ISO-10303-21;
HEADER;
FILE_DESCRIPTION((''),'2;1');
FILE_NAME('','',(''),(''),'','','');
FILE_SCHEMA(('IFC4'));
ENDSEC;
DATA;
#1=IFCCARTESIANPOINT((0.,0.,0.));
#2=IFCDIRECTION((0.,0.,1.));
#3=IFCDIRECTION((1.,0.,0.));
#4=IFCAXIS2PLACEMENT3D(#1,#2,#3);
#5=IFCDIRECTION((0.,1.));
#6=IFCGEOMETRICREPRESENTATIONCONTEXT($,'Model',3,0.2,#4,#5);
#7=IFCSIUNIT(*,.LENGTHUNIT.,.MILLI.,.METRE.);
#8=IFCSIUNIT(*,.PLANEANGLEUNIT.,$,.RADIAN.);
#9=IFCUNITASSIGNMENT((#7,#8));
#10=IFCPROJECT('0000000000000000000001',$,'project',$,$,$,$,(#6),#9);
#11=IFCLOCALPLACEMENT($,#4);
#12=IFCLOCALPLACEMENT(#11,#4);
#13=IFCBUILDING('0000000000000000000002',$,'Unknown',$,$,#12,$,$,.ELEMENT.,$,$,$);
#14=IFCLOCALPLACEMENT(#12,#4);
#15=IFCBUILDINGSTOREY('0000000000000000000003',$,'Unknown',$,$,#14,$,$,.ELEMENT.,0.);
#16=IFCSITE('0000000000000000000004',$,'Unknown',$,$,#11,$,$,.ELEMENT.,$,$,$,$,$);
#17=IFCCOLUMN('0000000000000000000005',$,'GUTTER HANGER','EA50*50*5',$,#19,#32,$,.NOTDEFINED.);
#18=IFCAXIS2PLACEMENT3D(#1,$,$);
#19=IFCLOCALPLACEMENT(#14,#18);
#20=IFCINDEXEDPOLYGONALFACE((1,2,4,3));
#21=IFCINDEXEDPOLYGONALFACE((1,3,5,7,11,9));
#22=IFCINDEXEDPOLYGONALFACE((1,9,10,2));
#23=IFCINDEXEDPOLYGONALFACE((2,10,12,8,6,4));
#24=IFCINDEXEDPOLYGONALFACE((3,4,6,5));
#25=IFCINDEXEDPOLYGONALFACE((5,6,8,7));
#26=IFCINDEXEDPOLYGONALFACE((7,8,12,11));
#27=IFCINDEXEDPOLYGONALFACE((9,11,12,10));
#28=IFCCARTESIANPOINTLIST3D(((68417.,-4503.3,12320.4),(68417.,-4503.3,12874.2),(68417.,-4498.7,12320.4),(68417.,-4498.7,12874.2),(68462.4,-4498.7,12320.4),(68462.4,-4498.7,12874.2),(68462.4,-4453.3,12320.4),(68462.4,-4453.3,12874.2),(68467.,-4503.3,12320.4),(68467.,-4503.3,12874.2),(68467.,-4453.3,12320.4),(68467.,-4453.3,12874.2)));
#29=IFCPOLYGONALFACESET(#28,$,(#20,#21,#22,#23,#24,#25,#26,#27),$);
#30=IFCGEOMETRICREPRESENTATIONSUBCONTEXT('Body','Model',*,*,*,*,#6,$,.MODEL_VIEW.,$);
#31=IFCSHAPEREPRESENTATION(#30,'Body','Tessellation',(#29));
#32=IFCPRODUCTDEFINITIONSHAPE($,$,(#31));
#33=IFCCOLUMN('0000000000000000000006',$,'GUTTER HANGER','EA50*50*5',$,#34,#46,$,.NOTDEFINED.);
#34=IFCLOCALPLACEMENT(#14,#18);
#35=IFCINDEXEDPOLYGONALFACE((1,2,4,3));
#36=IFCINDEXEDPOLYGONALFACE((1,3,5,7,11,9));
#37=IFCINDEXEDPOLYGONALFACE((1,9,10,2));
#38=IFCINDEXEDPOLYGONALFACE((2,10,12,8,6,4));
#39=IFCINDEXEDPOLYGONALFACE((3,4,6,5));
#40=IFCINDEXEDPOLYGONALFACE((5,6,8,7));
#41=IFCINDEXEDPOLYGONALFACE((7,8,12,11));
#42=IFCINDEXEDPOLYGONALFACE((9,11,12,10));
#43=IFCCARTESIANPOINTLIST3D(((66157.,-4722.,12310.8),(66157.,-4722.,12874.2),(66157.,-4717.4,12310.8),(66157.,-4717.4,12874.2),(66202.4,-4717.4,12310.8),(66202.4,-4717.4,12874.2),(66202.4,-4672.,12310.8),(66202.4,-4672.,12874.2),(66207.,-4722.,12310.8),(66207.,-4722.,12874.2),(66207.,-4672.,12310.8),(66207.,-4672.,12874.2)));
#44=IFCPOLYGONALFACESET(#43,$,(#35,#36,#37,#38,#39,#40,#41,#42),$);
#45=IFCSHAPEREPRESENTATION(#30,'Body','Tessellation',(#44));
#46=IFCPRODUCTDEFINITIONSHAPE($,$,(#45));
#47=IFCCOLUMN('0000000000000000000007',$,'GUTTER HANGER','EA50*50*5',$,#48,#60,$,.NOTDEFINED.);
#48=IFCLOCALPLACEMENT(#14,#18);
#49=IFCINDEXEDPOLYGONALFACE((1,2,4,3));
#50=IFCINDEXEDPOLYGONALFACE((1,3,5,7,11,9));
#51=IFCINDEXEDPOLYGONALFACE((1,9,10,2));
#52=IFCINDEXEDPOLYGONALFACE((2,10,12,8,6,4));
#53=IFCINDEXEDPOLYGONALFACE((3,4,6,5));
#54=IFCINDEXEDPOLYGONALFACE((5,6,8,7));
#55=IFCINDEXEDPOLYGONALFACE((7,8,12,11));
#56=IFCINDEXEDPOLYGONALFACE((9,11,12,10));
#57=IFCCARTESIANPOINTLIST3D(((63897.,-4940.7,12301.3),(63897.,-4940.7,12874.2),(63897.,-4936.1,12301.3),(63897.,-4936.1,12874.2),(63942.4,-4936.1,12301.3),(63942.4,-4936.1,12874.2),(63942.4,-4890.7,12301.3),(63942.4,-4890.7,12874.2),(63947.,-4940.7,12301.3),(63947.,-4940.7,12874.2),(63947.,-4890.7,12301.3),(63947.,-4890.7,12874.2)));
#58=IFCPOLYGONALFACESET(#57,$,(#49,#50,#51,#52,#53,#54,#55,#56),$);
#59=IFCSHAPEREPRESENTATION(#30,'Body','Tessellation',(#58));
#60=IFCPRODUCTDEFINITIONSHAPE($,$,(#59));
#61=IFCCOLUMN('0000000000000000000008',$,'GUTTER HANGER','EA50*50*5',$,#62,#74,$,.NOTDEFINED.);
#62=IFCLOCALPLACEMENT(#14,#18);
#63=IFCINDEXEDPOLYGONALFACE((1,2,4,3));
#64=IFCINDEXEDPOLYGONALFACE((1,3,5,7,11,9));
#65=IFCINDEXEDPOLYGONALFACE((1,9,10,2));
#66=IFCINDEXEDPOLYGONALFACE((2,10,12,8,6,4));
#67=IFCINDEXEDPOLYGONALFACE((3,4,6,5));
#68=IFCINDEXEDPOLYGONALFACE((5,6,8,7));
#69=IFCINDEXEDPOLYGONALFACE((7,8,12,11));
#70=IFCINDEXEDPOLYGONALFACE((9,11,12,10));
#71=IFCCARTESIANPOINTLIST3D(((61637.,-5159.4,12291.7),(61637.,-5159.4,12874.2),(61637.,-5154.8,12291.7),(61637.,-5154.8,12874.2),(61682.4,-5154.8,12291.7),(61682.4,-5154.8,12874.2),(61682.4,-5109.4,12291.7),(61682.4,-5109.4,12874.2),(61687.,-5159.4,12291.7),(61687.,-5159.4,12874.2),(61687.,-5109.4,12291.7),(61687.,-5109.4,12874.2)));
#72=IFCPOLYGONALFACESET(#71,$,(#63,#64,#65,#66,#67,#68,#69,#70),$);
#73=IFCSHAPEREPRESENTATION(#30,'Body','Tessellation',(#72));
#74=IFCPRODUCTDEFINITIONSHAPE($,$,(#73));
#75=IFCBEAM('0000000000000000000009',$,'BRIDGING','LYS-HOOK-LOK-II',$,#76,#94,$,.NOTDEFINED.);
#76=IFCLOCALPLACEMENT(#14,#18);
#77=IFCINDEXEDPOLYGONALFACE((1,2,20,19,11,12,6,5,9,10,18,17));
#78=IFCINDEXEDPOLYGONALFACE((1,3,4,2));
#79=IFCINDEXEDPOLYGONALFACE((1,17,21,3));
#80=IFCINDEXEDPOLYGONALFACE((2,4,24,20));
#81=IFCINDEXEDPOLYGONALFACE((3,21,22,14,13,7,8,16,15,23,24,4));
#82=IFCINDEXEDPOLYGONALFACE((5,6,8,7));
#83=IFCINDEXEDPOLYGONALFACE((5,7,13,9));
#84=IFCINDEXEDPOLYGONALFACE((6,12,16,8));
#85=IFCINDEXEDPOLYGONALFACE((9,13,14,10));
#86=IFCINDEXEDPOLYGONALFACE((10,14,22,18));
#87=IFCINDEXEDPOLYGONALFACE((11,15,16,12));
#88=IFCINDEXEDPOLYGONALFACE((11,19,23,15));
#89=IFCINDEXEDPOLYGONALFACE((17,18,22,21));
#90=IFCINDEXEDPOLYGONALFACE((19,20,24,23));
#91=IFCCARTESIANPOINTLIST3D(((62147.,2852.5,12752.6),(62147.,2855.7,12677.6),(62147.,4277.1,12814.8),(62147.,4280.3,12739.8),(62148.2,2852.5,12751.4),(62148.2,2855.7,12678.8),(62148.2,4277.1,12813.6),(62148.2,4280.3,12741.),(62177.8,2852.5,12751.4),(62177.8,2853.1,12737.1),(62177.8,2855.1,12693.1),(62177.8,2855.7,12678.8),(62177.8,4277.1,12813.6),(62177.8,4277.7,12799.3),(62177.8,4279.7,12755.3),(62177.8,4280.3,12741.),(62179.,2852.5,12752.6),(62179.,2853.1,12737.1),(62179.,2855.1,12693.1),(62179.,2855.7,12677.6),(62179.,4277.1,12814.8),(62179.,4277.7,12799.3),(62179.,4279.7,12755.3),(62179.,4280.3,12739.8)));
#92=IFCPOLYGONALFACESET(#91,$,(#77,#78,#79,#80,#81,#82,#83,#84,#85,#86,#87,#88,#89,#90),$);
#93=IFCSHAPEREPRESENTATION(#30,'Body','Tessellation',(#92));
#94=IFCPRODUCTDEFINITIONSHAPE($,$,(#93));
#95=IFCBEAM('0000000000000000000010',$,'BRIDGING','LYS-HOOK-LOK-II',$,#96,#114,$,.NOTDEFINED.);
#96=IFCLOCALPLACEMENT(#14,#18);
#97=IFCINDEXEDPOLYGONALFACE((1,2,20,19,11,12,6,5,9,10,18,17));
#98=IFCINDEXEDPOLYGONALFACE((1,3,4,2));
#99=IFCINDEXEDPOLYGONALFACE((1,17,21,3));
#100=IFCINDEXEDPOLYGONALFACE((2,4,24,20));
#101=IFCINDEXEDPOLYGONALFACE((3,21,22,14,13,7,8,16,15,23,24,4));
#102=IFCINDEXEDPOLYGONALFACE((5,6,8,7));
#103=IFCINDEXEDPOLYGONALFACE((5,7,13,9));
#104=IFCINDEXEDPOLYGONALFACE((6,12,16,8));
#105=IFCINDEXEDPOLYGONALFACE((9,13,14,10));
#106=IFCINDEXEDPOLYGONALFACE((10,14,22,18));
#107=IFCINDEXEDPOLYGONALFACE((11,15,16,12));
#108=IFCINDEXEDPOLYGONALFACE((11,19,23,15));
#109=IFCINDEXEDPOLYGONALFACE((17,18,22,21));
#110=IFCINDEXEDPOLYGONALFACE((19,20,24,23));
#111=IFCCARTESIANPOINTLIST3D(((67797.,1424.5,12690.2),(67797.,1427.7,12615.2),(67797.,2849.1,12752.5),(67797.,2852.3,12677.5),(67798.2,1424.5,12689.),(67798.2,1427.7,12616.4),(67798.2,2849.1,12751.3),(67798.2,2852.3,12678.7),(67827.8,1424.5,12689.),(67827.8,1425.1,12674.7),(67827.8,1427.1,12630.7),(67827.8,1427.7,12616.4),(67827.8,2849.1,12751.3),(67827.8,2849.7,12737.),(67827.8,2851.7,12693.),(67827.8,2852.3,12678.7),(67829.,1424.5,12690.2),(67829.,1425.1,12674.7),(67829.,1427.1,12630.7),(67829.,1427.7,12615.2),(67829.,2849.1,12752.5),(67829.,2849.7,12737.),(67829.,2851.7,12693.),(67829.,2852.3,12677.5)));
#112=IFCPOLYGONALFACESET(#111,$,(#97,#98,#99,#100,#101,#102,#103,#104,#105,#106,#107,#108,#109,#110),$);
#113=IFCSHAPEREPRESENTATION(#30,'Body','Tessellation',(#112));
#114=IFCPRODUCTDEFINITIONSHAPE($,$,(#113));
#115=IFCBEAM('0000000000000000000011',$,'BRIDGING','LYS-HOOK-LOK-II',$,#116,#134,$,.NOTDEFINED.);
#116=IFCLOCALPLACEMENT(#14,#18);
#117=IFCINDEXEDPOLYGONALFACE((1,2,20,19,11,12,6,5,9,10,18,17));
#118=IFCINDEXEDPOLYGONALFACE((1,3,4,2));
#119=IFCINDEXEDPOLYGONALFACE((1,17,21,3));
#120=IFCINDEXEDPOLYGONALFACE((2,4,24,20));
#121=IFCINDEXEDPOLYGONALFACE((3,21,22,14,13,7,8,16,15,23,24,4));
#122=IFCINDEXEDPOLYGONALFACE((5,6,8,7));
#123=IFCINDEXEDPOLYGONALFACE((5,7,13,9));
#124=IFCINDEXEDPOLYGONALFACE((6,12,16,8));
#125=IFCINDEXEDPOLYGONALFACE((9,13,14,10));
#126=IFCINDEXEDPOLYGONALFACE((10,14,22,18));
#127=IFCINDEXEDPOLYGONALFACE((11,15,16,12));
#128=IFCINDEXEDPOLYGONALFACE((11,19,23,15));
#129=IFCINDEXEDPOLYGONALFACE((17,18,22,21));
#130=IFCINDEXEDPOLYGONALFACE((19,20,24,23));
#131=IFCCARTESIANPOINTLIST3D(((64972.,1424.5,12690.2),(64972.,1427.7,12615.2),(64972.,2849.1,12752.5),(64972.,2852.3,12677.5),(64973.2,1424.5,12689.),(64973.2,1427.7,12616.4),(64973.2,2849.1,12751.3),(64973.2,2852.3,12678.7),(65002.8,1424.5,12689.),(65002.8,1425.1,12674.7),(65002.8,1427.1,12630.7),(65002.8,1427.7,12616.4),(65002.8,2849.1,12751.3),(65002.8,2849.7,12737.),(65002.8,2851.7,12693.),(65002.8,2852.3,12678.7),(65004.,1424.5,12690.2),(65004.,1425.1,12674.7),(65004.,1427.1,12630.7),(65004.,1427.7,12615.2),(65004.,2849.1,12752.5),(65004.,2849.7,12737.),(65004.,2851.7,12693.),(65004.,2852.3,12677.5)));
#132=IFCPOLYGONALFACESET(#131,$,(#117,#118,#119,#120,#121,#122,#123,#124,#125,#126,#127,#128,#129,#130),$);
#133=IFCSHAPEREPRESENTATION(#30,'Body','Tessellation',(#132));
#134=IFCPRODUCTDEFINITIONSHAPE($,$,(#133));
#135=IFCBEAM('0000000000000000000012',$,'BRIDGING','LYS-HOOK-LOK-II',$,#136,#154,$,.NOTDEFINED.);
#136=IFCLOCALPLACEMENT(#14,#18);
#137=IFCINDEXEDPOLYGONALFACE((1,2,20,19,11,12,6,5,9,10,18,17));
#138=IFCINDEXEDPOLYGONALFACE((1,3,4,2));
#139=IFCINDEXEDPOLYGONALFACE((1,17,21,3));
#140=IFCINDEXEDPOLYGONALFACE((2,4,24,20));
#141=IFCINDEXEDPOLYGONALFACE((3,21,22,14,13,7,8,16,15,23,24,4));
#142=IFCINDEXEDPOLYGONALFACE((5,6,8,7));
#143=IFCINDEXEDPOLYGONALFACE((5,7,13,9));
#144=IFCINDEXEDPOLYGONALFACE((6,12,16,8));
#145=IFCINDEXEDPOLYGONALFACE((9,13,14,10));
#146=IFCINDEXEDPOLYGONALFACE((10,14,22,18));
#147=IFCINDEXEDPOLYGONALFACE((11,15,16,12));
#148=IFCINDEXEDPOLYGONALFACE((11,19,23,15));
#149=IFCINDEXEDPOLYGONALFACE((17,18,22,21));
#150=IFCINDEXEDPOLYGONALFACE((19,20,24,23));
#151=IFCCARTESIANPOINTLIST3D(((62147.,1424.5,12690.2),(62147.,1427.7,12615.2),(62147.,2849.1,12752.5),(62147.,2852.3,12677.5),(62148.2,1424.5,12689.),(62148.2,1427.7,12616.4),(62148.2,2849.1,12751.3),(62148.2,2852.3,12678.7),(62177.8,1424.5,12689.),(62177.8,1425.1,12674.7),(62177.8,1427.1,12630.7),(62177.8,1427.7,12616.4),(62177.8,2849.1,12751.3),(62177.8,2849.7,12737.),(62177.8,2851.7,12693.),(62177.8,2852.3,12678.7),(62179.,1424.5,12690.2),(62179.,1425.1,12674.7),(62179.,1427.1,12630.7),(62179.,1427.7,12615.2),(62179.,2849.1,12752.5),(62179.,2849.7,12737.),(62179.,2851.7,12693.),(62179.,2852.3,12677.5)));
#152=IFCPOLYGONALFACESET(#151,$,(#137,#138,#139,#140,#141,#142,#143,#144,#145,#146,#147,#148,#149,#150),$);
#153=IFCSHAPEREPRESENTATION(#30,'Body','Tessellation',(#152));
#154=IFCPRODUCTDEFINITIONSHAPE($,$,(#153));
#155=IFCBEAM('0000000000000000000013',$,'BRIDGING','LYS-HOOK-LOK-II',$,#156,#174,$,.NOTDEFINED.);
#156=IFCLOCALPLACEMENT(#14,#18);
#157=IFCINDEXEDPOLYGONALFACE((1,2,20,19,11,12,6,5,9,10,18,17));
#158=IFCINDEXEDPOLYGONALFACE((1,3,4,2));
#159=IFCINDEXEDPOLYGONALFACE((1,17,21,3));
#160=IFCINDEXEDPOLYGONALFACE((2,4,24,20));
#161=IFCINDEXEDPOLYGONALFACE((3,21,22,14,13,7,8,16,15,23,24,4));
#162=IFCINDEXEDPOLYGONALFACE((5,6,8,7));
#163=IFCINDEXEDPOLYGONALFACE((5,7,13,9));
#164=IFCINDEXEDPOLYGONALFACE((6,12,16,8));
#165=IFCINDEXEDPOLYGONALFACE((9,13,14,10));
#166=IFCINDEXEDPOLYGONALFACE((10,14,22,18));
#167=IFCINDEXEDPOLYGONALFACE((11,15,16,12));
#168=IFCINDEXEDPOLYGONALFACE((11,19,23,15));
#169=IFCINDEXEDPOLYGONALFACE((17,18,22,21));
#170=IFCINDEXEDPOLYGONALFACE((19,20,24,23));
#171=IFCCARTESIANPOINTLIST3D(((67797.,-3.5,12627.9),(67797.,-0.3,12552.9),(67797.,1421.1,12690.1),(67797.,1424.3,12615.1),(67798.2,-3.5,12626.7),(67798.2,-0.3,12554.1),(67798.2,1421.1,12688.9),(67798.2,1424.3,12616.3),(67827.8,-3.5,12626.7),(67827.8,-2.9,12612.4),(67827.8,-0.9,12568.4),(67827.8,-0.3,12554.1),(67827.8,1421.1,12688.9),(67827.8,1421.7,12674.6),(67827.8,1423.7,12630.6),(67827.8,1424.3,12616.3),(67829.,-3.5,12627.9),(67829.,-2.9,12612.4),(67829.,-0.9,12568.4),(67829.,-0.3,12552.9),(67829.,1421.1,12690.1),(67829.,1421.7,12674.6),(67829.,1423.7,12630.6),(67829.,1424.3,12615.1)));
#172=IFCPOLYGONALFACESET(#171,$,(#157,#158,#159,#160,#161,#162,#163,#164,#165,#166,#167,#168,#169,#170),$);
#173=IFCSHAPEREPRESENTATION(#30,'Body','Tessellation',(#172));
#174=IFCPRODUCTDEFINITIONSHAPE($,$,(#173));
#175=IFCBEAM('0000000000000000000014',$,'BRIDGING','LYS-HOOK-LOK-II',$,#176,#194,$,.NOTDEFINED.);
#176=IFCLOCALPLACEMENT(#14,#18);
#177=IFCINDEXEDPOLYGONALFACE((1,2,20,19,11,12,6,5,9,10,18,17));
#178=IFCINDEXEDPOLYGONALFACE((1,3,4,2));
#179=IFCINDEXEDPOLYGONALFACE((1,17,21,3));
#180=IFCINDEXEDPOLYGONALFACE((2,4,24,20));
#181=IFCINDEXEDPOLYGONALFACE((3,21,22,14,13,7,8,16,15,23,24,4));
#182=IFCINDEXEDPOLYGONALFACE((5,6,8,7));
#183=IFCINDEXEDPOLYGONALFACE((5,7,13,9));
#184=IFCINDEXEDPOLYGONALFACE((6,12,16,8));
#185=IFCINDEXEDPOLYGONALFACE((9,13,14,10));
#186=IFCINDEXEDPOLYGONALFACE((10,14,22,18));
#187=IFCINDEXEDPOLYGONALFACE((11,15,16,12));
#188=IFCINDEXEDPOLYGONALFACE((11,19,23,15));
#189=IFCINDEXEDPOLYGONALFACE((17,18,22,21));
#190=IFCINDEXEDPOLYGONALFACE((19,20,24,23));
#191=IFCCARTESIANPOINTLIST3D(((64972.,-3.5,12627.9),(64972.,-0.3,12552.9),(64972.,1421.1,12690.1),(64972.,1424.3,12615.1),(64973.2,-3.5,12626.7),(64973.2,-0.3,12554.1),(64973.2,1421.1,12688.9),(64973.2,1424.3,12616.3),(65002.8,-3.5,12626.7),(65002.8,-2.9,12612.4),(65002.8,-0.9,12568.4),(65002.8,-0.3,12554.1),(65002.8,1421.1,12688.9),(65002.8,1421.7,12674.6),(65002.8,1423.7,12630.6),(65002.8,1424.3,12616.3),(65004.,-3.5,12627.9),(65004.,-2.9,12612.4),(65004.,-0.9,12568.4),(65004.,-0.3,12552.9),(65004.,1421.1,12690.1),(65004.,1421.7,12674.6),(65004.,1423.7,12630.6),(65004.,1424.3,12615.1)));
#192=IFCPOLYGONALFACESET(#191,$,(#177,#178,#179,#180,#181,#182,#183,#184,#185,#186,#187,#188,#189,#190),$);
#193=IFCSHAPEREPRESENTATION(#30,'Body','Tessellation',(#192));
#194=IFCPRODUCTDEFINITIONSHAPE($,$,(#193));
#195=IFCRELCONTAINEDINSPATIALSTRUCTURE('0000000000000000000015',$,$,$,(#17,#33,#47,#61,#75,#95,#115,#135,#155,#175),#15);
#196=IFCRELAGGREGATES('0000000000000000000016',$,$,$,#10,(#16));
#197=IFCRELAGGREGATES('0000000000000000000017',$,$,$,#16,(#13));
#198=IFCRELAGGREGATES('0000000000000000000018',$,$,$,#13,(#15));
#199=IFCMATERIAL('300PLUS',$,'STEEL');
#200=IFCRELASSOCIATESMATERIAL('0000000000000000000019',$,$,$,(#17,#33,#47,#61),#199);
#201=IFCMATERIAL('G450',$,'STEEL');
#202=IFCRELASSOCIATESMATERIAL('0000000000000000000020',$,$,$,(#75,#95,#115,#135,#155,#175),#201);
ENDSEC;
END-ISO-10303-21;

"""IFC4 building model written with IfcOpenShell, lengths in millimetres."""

from ifc_helpers import new_model, si_unit, direction, frame, origin_with_axes, place, context, subcontext, project, spatial, line, indexed_curve, outline, extrude, material, element, save


model = new_model("IFC4")

# Units and contexts
model_context = context("Model", 3, precision=0.2, world=origin_with_axes(), true_north=direction((0.0, 1.0)))
body_context = subcontext(model_context, "Body", "Model", "MODEL_VIEW")
ifc_project = project(units=[si_unit("LENGTHUNIT", "METRE", prefix="MILLI"), si_unit("PLANEANGLEUNIT", "RADIAN")], contexts=[model_context])

# Site, building, storey
site_placement = place(None, origin_with_axes())
site = spatial("IfcSite", under=ifc_project, at=site_placement, Name="Unknown", CompositionType="ELEMENT")
building_placement = place(site_placement, origin_with_axes())
building = spatial("IfcBuilding", under=site, at=building_placement, Name="Unknown", CompositionType="ELEMENT")
storey_placement = place(building_placement, origin_with_axes())
storey = spatial("IfcBuildingStorey", under=building, at=storey_placement, Name="Unknown", CompositionType="ELEMENT", Elevation=0.0)

# Columns
ifc_material_1 = material(Name="300PLUS", Category="STEEL")
column_1_placement = place(storey_placement, frame((68442.0, -4478.3, 12320.4), z_axis=(-1.0, 0.0, 0.0), x_axis=(0.0, 0.0, 1.0)))
element("IfcColumn", 1, at=column_1_placement, inside=storey, material=ifc_material_1, Name="GUTTER HANGER", Description="EA50*50*5", PredefinedType="NOTDEFINED", context=body_context, shape_type="SolidModel", body=[
    extrude(outline(indexed_curve([(-25.0, -25.0), (25.0, -25.0), (25.0, -20.4), (-20.4, -20.4), (-20.4, 25.0), (-25.0, 25.0)], segments=[line(1, 2, 3, 4, 5, 6, 1)])), frame((0.0, 0.0, 0.0), z_axis=(-1.0, 0.0, 0.0), x_axis=(0.0, 0.0, 1.0)), (0.0, 0.0, -1.0), 553.8),
])
column_2_placement = place(storey_placement, frame((66182.0, -4697.0, 12310.8), z_axis=(-1.0, 0.0, 0.0), x_axis=(0.0, 0.0, 1.0)))
element("IfcColumn", 2, at=column_2_placement, inside=storey, material=ifc_material_1, Name="GUTTER HANGER", Description="EA50*50*5", PredefinedType="NOTDEFINED", context=body_context, shape_type="SolidModel", body=[
    extrude(outline(indexed_curve([(-25.0, -25.0), (25.0, -25.0), (25.0, -20.4), (-20.4, -20.4), (-20.4, 25.0), (-25.0, 25.0)], segments=[line(1, 2, 3, 4, 5, 6, 1)])), frame((0.0, 0.0, 0.0), z_axis=(-1.0, 0.0, 0.0), x_axis=(0.0, 0.0, 1.0)), (0.0, 0.0, -1.0), 563.4),
])
column_3_placement = place(storey_placement, frame((63922.0, -4915.7, 12301.3), z_axis=(-1.0, 0.0, 0.0), x_axis=(0.0, 0.0, 1.0)))
element("IfcColumn", 3, at=column_3_placement, inside=storey, material=ifc_material_1, Name="GUTTER HANGER", Description="EA50*50*5", PredefinedType="NOTDEFINED", context=body_context, shape_type="SolidModel", body=[
    extrude(outline(indexed_curve([(-25.0, -25.0), (25.0, -25.0), (25.0, -20.4), (-20.4, -20.4), (-20.4, 25.0), (-25.0, 25.0)], segments=[line(1, 2, 3, 4, 5, 6, 1)])), frame((0.0, 0.0, 0.0), z_axis=(-1.0, 0.0, 0.0), x_axis=(0.0, 0.0, 1.0)), (0.0, 0.0, -1.0), 572.9),
])
column_4_placement = place(storey_placement, frame((61662.0, -5134.4, 12291.7), z_axis=(-1.0, 0.0, 0.0), x_axis=(0.0, 0.0, 1.0)))
element("IfcColumn", 4, at=column_4_placement, inside=storey, material=ifc_material_1, Name="GUTTER HANGER", Description="EA50*50*5", PredefinedType="NOTDEFINED", context=body_context, shape_type="SolidModel", body=[
    extrude(outline(indexed_curve([(-25.0, -25.0), (25.0, -25.0), (25.0, -20.4), (-20.4, -20.4), (-20.4, 25.0), (-25.0, 25.0)], segments=[line(1, 2, 3, 4, 5, 6, 1)])), frame((0.0, 0.0, 0.0), z_axis=(-1.0, 0.0, 0.0), x_axis=(0.0, 0.0, 1.0)), (0.0, 0.0, -1.0), 582.5),
])

# Beams
ifc_material_2 = material(Name="G450", Category="STEEL")
beam_1_placement = place(storey_placement, frame((62163.0, 2854.1, 12715.1), z_axis=(1.0, 0.0, 0.0), x_axis=(0.0, 0.999048, 0.04362)))
element("IfcBeam", 5, at=beam_1_placement, inside=storey, material=ifc_material_2, Name="BRIDGING", Description="LYS-HOOK-LOK-II", PredefinedType="NOTDEFINED", context=body_context, shape_type="SolidModel", body=[
    extrude(outline(indexed_curve([(16.0, -37.5), (16.0, -22.0), (14.8, -22.0), (14.8, -36.3), (-14.8, -36.3), (-14.8, 36.3), (14.8, 36.3), (14.8, 22.0), (16.0, 22.0), (16.0, 37.5), (-16.0, 37.5), (-16.0, -37.5)], segments=[line(1, 2, 3, 4, 5, 6, 7, 8, 9, 10, 11, 12, 1)])), frame((0.0, 0.0, 0.0), z_axis=(-1.0, 0.0, 0.0), x_axis=(0.0, 0.0, 1.0)), (0.0, 0.0, -1.0), 1426.0),
])
for number, where, z_axis, x_axis, name in (
    (6, (67813.0, 1426.1, 12652.7), (1.0, 0.0, 0.0), (0.0, 0.999045, 0.04369), "BRIDGING"),
    (7, (64988.0, 1426.1, 12652.7), (1.0, 0.0, 0.0), (0.0, 0.999045, 0.04369), "BRIDGING"),
    (8, (62163.0, 1426.1, 12652.7), (1.0, 0.0, 0.0), (0.0, 0.999045, 0.04369), "BRIDGING"),
):
    element("IfcBeam", number, at=place(storey_placement, frame(where, z_axis=z_axis, x_axis=x_axis)), inside=storey, material=ifc_material_2, Name=name, Description="LYS-HOOK-LOK-II", PredefinedType="NOTDEFINED", context=body_context, shape_type="SolidModel", body=[
        extrude(outline(indexed_curve([(16.0, -37.5), (16.0, -22.0), (14.8, -22.0), (14.8, -36.3), (-14.8, -36.3), (-14.8, 36.3), (14.8, 36.3), (14.8, 22.0), (16.0, 22.0), (16.0, 37.5), (-16.0, 37.5), (-16.0, -37.5)], segments=[line(1, 2, 3, 4, 5, 6, 7, 8, 9, 10, 11, 12, 1)])), frame((0.0, 0.0, 0.0), z_axis=(-1.0, 0.0, 0.0), x_axis=(0.0, 0.0, 1.0)), (0.0, 0.0, -1.0), 1426.0),
    ])
for number, where, z_axis, x_axis, name in (
    (9, (67813.0, -1.9, 12590.4), (1.0, 0.0, 0.0), (0.0, 0.999048, 0.04362), "BRIDGING"),
    (10, (64988.0, -1.9, 12590.4), (1.0, 0.0, 0.0), (0.0, 0.999048, 0.04362), "BRIDGING"),
):
    element("IfcBeam", number, at=place(storey_placement, frame(where, z_axis=z_axis, x_axis=x_axis)), inside=storey, material=ifc_material_2, Name=name, Description="LYS-HOOK-LOK-II", PredefinedType="NOTDEFINED", context=body_context, shape_type="SolidModel", body=[
        extrude(outline(indexed_curve([(16.0, -37.5), (16.0, -22.0), (14.8, -22.0), (14.8, -36.3), (-14.8, -36.3), (-14.8, 36.3), (14.8, 36.3), (14.8, 22.0), (16.0, 22.0), (16.0, 37.5), (-16.0, 37.5), (-16.0, -37.5)], segments=[line(1, 2, 3, 4, 5, 6, 7, 8, 9, 10, 11, 12, 1)])), frame((0.0, 0.0, 0.0), z_axis=(-1.0, 0.0, 0.0), x_axis=(0.0, 0.0, 1.0)), (0.0, 0.0, -1.0), 1426.0),
    ])

save(model, "model.ifc")
